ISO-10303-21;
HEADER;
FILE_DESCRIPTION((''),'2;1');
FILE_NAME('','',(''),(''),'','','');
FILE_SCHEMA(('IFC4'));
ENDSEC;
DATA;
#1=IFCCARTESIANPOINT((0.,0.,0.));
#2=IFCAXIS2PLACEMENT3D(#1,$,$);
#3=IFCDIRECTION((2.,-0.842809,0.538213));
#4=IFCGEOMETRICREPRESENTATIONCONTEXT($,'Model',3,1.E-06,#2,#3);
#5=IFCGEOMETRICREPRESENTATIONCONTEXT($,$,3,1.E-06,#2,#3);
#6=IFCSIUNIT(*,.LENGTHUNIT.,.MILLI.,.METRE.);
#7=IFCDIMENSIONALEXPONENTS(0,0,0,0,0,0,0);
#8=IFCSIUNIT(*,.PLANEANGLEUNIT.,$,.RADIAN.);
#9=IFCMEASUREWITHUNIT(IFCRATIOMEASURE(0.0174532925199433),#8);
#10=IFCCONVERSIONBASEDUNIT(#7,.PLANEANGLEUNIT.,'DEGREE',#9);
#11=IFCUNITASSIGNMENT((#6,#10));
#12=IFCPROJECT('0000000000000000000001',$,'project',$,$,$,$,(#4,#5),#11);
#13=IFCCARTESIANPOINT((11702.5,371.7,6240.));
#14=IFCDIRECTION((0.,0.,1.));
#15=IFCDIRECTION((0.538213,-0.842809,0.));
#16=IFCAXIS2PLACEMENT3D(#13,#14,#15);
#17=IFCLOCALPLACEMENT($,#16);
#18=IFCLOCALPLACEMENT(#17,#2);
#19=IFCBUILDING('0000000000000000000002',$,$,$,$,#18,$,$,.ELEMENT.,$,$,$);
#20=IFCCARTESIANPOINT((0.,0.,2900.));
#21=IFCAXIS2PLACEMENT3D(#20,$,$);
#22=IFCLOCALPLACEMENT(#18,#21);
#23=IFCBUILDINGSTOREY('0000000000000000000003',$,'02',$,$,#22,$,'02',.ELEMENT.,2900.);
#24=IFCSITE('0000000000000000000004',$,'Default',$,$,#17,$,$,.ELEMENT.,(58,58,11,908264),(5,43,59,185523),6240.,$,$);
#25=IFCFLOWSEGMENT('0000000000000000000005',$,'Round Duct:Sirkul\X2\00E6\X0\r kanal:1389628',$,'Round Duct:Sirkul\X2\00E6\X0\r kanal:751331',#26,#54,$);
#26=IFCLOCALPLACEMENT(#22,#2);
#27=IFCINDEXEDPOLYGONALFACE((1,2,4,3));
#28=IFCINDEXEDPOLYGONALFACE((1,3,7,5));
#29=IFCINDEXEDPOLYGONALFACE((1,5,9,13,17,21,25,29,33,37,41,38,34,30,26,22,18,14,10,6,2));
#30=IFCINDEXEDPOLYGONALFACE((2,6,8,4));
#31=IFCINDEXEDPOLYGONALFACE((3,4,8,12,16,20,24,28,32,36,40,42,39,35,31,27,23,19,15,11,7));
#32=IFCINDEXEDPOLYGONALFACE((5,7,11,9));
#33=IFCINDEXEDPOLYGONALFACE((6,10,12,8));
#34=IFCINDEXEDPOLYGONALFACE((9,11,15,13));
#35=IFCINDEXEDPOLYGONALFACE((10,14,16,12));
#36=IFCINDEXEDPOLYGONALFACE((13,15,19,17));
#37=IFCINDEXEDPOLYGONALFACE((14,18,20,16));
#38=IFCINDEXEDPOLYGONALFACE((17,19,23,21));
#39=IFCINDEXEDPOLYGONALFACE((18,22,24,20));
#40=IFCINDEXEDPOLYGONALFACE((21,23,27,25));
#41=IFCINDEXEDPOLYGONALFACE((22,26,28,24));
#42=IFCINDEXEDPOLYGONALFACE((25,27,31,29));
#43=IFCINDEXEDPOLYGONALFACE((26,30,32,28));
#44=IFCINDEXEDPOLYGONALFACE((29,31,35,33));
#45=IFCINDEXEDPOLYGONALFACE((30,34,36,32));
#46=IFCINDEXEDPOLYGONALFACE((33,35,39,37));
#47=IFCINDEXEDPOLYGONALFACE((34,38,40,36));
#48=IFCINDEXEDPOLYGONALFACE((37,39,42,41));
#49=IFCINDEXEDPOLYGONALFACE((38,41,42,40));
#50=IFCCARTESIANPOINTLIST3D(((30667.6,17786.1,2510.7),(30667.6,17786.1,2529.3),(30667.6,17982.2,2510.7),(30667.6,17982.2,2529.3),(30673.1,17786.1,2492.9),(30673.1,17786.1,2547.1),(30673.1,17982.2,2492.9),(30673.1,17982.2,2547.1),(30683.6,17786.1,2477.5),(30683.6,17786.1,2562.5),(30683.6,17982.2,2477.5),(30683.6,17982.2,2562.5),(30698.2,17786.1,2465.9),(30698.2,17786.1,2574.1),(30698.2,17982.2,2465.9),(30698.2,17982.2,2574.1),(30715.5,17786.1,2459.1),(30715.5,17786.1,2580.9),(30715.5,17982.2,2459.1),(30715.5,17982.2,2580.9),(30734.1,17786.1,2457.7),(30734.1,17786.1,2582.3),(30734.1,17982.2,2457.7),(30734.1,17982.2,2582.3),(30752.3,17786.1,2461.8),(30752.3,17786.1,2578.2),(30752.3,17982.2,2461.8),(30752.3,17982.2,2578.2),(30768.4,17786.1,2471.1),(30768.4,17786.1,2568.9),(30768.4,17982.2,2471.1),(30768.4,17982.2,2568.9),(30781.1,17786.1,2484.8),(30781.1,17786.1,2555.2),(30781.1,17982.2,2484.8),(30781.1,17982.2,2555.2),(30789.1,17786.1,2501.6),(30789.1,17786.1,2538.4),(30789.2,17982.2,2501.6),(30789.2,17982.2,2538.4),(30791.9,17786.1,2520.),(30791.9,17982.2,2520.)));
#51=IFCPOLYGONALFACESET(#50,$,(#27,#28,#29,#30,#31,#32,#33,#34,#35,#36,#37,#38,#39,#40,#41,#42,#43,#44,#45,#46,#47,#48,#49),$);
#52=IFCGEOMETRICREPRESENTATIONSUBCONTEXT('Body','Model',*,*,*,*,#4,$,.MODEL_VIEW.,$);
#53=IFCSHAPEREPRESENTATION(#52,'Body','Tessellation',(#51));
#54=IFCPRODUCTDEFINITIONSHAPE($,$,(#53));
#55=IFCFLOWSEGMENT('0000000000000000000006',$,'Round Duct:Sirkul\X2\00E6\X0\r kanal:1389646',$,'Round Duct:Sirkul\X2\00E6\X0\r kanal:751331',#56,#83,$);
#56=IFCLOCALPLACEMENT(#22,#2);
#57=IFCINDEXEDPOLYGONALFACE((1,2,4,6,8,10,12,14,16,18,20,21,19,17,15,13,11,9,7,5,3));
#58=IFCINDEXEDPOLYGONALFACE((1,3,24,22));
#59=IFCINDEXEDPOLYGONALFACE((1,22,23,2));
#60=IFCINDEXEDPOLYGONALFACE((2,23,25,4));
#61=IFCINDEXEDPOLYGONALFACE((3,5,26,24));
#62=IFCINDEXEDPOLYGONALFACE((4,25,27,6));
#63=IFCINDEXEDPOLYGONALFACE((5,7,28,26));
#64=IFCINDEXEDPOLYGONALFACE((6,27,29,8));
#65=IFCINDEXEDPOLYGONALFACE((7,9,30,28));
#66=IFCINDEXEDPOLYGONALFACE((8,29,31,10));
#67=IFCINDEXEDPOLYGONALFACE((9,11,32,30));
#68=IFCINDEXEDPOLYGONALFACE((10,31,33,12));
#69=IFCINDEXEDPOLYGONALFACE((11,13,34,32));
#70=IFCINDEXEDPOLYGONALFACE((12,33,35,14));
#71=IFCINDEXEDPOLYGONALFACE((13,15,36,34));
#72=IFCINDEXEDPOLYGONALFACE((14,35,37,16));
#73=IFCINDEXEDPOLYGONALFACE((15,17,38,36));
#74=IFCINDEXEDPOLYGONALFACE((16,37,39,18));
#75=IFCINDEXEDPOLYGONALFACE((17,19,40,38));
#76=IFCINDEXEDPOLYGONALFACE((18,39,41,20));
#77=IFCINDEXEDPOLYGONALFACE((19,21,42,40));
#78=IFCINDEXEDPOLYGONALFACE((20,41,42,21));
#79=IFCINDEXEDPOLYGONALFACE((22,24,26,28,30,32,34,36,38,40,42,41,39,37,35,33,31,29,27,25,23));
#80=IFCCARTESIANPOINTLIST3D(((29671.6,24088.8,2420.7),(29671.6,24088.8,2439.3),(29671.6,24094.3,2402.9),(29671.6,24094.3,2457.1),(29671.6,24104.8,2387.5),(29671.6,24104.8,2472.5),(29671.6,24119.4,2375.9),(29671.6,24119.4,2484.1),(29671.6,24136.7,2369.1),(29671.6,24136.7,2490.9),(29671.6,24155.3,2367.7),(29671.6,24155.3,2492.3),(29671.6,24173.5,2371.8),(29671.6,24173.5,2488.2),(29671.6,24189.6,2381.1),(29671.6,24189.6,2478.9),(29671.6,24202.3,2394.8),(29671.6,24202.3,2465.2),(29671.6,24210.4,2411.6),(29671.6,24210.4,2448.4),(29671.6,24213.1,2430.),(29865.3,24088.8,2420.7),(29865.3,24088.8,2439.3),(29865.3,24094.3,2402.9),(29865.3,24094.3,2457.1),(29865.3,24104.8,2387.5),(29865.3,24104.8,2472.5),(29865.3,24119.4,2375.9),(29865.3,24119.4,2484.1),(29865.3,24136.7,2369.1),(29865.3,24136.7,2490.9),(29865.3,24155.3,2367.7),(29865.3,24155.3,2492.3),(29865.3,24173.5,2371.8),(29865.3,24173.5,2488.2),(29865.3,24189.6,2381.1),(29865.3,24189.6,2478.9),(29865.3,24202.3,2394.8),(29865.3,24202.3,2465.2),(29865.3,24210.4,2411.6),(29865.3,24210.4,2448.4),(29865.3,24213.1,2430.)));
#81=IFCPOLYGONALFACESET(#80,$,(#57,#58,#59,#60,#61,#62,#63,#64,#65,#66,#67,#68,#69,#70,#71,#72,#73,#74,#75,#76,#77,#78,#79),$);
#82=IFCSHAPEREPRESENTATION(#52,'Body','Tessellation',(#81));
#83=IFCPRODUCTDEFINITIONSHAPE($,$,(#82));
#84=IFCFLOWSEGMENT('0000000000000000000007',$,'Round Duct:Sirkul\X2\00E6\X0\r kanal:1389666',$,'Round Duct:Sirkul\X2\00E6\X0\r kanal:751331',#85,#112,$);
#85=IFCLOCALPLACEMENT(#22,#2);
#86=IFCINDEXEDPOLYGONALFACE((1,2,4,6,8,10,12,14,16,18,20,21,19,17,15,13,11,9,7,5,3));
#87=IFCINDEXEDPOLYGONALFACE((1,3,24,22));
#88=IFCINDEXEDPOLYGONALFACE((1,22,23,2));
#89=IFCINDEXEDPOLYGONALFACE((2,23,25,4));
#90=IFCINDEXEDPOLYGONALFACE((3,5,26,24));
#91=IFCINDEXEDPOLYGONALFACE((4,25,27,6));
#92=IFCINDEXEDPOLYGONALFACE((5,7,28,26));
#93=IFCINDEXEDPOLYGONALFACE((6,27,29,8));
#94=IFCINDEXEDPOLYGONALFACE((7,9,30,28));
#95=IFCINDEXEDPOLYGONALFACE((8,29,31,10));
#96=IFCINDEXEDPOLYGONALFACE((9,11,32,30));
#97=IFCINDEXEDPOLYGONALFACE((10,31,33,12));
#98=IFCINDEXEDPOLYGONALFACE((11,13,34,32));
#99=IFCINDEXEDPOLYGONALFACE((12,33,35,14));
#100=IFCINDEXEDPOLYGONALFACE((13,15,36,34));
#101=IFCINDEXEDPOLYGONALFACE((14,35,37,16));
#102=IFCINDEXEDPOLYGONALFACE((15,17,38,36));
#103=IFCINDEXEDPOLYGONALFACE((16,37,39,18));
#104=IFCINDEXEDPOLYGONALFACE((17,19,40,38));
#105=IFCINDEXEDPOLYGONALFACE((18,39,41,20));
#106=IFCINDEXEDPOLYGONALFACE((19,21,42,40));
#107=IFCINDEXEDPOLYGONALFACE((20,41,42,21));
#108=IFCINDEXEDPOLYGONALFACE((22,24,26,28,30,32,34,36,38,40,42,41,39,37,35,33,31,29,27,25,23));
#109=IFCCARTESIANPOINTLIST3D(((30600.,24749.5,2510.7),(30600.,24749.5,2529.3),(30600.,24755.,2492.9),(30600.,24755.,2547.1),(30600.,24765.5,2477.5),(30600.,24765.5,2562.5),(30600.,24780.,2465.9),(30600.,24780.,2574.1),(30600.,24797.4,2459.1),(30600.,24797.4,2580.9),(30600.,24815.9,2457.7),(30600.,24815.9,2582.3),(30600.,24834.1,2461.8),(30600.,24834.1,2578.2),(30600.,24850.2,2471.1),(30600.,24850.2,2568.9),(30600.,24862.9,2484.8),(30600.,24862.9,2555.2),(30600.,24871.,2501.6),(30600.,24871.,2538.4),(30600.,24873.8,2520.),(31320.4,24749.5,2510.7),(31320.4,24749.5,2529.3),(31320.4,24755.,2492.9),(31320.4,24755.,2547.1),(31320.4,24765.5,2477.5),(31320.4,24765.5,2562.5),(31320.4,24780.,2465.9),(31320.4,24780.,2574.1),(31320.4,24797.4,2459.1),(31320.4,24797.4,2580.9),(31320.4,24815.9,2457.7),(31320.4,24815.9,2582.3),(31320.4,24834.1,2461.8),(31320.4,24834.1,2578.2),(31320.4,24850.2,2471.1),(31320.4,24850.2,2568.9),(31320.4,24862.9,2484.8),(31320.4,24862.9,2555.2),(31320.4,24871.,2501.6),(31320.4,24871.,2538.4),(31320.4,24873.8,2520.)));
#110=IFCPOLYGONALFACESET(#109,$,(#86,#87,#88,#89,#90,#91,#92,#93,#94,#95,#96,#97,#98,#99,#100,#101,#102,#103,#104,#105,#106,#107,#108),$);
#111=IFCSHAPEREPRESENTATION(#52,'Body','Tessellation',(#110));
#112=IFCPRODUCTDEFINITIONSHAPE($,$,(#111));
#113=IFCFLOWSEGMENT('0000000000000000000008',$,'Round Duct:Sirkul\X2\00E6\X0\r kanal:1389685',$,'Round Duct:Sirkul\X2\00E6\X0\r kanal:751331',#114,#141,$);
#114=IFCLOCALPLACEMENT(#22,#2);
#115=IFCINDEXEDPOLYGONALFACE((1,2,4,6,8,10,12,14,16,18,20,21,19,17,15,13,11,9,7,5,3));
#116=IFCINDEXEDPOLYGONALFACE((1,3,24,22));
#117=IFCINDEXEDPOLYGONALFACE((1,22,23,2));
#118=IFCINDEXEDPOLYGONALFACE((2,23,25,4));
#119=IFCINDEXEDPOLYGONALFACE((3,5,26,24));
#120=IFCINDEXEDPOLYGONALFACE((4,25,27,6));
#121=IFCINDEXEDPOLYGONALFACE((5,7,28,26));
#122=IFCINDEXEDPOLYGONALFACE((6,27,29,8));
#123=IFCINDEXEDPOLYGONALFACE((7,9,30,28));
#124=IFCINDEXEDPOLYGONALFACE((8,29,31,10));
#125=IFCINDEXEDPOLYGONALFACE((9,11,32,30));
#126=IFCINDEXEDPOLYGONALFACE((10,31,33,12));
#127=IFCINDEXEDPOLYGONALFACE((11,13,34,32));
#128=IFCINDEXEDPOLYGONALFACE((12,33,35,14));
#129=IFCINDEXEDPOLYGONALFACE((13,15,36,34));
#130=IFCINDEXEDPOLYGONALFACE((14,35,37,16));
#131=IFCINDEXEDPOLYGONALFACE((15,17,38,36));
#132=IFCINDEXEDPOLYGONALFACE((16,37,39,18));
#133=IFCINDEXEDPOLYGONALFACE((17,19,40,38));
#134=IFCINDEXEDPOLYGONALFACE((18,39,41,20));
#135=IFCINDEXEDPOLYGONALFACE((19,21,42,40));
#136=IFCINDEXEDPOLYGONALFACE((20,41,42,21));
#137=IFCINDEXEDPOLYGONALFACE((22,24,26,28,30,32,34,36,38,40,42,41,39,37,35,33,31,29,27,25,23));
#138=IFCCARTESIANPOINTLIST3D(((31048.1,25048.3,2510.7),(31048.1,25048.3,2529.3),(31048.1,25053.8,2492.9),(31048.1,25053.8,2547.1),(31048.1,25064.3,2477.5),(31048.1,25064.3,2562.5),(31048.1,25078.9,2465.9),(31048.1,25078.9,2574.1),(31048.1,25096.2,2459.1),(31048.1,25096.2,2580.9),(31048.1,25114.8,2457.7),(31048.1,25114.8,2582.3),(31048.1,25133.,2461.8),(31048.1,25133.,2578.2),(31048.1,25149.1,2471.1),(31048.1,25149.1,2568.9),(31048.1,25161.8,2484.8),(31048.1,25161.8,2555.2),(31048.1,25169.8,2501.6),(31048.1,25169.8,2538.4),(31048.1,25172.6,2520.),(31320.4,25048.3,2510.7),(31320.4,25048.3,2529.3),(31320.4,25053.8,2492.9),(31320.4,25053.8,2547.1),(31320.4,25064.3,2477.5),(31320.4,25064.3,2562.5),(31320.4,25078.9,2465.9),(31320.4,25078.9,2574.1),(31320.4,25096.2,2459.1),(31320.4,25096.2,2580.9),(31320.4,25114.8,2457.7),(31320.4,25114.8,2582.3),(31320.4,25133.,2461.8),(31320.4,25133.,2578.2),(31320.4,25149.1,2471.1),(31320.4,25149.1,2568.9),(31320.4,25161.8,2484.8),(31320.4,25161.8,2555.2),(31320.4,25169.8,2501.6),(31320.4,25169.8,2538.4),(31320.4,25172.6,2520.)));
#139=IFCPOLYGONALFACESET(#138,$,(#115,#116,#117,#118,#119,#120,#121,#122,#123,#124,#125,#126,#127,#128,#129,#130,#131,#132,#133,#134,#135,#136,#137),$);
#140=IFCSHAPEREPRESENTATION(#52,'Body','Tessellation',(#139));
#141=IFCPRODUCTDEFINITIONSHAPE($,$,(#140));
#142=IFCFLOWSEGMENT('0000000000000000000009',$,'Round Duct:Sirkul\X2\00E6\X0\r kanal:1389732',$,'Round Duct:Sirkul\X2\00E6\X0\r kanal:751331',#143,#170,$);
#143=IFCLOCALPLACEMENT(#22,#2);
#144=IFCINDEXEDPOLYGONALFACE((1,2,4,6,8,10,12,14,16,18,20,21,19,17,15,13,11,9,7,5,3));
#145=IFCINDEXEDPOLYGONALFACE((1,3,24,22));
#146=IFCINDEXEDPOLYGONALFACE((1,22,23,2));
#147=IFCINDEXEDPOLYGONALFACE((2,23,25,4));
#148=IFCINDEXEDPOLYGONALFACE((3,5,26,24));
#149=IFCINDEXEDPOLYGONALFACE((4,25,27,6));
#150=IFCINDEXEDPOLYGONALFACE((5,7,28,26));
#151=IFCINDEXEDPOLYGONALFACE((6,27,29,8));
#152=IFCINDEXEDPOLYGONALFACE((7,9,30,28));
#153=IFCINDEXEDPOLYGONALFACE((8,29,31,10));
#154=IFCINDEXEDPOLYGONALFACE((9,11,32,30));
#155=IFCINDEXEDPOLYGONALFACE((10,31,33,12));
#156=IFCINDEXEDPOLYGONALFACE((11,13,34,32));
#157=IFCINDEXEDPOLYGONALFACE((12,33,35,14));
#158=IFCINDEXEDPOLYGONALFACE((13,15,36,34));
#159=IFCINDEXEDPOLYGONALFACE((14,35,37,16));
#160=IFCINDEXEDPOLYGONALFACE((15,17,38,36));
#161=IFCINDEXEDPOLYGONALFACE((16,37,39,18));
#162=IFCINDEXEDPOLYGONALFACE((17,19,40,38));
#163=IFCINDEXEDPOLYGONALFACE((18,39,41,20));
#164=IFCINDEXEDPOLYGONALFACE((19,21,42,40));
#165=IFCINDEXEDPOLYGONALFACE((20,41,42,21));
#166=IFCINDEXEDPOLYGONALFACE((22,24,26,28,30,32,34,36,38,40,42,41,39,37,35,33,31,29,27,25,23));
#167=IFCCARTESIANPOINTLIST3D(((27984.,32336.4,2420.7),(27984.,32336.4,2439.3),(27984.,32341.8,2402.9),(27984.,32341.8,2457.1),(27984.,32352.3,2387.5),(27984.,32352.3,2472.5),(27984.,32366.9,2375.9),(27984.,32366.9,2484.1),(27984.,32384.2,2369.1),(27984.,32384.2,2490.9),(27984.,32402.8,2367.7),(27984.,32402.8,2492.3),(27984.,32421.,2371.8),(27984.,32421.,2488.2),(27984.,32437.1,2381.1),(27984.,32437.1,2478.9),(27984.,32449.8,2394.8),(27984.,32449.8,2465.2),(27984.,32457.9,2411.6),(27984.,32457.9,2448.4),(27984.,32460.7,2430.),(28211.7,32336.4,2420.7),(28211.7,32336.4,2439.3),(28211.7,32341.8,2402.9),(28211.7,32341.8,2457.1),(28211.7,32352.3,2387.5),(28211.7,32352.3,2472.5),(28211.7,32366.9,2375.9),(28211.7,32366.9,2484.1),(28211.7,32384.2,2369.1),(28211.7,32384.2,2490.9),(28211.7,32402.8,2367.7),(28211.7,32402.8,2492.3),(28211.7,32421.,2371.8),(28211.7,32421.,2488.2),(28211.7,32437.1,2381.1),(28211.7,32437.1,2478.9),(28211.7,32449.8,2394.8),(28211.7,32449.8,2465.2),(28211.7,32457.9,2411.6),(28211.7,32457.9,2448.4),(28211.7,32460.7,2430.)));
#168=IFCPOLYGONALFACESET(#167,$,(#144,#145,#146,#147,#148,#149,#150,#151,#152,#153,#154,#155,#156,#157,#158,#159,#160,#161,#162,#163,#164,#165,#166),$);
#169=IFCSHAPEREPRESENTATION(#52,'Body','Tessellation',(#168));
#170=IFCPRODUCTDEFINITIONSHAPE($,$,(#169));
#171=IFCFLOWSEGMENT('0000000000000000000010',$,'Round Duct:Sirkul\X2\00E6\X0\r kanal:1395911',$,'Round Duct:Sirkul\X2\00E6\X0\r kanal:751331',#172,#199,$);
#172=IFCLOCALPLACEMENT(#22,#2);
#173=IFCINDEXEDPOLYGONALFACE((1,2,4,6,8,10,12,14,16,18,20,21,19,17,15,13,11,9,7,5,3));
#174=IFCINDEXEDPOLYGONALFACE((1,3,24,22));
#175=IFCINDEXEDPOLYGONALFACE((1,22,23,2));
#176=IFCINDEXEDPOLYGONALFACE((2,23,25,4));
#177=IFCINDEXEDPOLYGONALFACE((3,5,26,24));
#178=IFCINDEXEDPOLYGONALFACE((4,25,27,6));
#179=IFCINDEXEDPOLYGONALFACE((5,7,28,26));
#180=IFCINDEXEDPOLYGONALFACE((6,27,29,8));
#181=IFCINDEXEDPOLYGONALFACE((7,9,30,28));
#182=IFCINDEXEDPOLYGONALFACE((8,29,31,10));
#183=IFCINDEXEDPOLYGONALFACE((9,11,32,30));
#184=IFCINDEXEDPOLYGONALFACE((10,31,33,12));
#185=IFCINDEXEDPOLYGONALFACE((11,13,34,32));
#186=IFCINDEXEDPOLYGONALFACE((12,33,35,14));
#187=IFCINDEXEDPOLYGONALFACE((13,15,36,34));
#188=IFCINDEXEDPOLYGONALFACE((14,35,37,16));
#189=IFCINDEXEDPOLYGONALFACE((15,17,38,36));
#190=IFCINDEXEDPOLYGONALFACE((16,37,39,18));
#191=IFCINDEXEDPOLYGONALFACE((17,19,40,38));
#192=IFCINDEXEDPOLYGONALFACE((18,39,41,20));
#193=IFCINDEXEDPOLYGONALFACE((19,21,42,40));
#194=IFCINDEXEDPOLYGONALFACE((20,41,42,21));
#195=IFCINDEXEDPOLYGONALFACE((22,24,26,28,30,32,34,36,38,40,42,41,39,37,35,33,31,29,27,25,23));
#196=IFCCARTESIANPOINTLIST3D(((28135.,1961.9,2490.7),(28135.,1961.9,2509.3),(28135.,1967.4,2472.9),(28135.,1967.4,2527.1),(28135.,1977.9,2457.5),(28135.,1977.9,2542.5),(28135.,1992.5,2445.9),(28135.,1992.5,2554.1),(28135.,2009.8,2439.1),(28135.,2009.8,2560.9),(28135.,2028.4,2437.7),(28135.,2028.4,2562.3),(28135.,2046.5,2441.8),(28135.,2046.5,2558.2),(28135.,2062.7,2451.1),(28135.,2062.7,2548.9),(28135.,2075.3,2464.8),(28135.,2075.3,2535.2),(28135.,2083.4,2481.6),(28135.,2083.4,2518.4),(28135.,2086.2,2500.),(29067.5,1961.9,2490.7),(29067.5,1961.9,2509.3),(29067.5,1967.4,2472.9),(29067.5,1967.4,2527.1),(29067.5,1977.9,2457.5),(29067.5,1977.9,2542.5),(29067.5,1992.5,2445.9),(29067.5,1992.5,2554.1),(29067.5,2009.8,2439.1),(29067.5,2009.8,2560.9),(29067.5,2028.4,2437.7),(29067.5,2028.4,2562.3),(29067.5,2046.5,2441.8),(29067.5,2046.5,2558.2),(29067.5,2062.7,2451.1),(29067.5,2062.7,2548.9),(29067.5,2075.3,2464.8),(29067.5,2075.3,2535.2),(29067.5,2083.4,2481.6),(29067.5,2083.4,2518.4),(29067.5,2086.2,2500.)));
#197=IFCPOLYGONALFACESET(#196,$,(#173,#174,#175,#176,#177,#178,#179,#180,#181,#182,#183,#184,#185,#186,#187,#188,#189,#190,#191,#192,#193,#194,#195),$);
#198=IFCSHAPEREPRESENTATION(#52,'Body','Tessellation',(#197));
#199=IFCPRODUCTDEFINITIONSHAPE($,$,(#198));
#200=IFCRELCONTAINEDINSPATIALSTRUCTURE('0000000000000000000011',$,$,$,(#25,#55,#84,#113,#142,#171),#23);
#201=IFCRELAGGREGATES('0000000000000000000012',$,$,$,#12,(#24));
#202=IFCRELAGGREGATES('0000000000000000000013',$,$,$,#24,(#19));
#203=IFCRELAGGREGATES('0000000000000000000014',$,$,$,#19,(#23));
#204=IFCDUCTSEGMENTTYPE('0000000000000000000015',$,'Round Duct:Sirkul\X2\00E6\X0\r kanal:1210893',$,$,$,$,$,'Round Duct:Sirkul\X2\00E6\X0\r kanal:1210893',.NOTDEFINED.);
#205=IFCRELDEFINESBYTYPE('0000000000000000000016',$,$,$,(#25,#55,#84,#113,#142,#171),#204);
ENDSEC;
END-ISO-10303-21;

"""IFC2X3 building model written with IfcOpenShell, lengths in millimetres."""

from ifc_helpers import new_model, entity, si_unit, converted_unit, direction, frame, frame_2d, origin, origin_2d_with_axis, place, context, subcontext, project, spatial, circle, extrude, type_object, element, save


model = new_model("IFC2X3")

# Units and contexts
model_context = context("Model", 3, precision=1e-06, world=origin(), true_north=direction((2.0, -0.842809, 0.538213)))
context_of_model = context(None, 3, precision=1e-06, world=origin(), true_north=direction((2.0, -0.842809, 0.538213)))
body_context = subcontext(model_context, "Body", "Model", "MODEL_VIEW")
ifc_project = project(units=[si_unit("LENGTHUNIT", "METRE", prefix="MILLI"), converted_unit("PLANEANGLEUNIT", "DEGREE", entity("IfcRatioMeasure", 0.0174532925199433), si_unit("PLANEANGLEUNIT", "RADIAN"), dimensions=[0, 0, 0, 0, 0, 0, 0])], contexts=[model_context, context_of_model])

# Site, building, storey
site_placement = place(None, frame((11702.5, 371.7, 6240.0), z_axis=(0.0, 0.0, 1.0), x_axis=(0.538213, -0.842809, 0.0)))
site = spatial("IfcSite", under=ifc_project, at=site_placement, Name="Default", CompositionType="ELEMENT", RefLatitude=(58, 58, 11, 908264), RefLongitude=(5, 43, 59, 185523), RefElevation=6240.0)
building_placement = place(site_placement, origin())
building = spatial("IfcBuilding", under=site, at=building_placement, CompositionType="ELEMENT")
storey_placement = place(building_placement, frame((0.0, 0.0, 2900.0)))
storey = spatial("IfcBuildingStorey", under=building, at=storey_placement, Name="02", LongName="02", CompositionType="ELEMENT", Elevation=2900.0)

# Flow segments
duct_segment_type = type_object("IfcDuctSegmentType", Name="Round Duct:Sirkulær kanal:1210893", ElementType="Round Duct:Sirkulær kanal:1210893", PredefinedType="NOTDEFINED")
flow_segment_1_placement = place(storey_placement, origin())
element("IfcFlowSegment", 1, at=flow_segment_1_placement, inside=storey, type_object=duct_segment_type, Name="Round Duct:Sirkulær kanal:1389628", ObjectType="Round Duct:Sirkulær kanal:751331", context=body_context, shape_type="SweptSolid", body=[
    extrude(circle(Radius=62.5, at=origin_2d_with_axis()), frame((30729.4, 17786.1, 2520.0), z_axis=(0.000053, 1.0, 0.0), x_axis=(1.0, -0.000053, 0.0)), (0.0, 0.0, 1.0), 196.1),
])
flow_segment_2_placement = place(storey_placement, origin())
element("IfcFlowSegment", 2, at=flow_segment_2_placement, inside=storey, type_object=duct_segment_type, Name="Round Duct:Sirkulær kanal:1389646", ObjectType="Round Duct:Sirkulær kanal:751331", context=body_context, shape_type="SweptSolid", body=[
    extrude(circle(Radius=62.5, at=origin_2d_with_axis()), frame((29671.6, 24150.6, 2430.0), z_axis=(1.0, 0.0, 0.0), x_axis=(0.0, 1.0, 0.0)), (0.0, 0.0, 1.0), 193.7),
])
flow_segment_3_placement = place(storey_placement, origin())
element("IfcFlowSegment", 3, at=flow_segment_3_placement, inside=storey, type_object=duct_segment_type, Name="Round Duct:Sirkulær kanal:1389666", ObjectType="Round Duct:Sirkulær kanal:751331", context=body_context, shape_type="SweptSolid", body=[
    extrude(circle(Radius=62.5, at=origin_2d_with_axis()), frame((30600.0, 24811.3, 2520.0), z_axis=(1.0, 0.0, 0.0), x_axis=(0.0, 1.0, 0.0)), (0.0, 0.0, 1.0), 720.3),
])
flow_segment_4_placement = place(storey_placement, origin())
element("IfcFlowSegment", 4, at=flow_segment_4_placement, inside=storey, type_object=duct_segment_type, Name="Round Duct:Sirkulær kanal:1389685", ObjectType="Round Duct:Sirkulær kanal:751331", context=body_context, shape_type="SweptSolid", body=[
    extrude(circle(Radius=62.5, at=origin_2d_with_axis()), frame((31048.1, 25110.1, 2520.0), z_axis=(1.0, 0.0, 0.0), x_axis=(0.0, 1.0, 0.0)), (0.0, 0.0, 1.0), 272.2),
])
flow_segment_5_placement = place(storey_placement, origin())
element("IfcFlowSegment", 5, at=flow_segment_5_placement, inside=storey, type_object=duct_segment_type, Name="Round Duct:Sirkulær kanal:1389732", ObjectType="Round Duct:Sirkulær kanal:751331", context=body_context, shape_type="SweptSolid", body=[
    extrude(circle(Radius=62.5, at=frame_2d((0.0, 0.0), x_axis=(1.0, 0.0))), frame((27984.0, 32398.2, 2430.0), z_axis=(1.0, 0.0, 0.0), x_axis=(0.0, 1.0, 0.0)), (0.0, 0.0, 1.0), 227.8),
])
flow_segment_6_placement = place(storey_placement, origin())
element("IfcFlowSegment", 6, at=flow_segment_6_placement, inside=storey, type_object=duct_segment_type, Name="Round Duct:Sirkulær kanal:1395911", ObjectType="Round Duct:Sirkulær kanal:751331", context=body_context, shape_type="SweptSolid", body=[
    extrude(circle(Radius=62.5, at=frame_2d((0.0, 0.0), x_axis=(1.0, 0.0))), frame((28135.0, 2023.7, 2500.0), z_axis=(1.0, 0.0, 0.0), x_axis=(0.0, 1.0, 0.0)), (0.0, 0.0, 1.0), 932.5),
])

save(model, "model.ifc")
